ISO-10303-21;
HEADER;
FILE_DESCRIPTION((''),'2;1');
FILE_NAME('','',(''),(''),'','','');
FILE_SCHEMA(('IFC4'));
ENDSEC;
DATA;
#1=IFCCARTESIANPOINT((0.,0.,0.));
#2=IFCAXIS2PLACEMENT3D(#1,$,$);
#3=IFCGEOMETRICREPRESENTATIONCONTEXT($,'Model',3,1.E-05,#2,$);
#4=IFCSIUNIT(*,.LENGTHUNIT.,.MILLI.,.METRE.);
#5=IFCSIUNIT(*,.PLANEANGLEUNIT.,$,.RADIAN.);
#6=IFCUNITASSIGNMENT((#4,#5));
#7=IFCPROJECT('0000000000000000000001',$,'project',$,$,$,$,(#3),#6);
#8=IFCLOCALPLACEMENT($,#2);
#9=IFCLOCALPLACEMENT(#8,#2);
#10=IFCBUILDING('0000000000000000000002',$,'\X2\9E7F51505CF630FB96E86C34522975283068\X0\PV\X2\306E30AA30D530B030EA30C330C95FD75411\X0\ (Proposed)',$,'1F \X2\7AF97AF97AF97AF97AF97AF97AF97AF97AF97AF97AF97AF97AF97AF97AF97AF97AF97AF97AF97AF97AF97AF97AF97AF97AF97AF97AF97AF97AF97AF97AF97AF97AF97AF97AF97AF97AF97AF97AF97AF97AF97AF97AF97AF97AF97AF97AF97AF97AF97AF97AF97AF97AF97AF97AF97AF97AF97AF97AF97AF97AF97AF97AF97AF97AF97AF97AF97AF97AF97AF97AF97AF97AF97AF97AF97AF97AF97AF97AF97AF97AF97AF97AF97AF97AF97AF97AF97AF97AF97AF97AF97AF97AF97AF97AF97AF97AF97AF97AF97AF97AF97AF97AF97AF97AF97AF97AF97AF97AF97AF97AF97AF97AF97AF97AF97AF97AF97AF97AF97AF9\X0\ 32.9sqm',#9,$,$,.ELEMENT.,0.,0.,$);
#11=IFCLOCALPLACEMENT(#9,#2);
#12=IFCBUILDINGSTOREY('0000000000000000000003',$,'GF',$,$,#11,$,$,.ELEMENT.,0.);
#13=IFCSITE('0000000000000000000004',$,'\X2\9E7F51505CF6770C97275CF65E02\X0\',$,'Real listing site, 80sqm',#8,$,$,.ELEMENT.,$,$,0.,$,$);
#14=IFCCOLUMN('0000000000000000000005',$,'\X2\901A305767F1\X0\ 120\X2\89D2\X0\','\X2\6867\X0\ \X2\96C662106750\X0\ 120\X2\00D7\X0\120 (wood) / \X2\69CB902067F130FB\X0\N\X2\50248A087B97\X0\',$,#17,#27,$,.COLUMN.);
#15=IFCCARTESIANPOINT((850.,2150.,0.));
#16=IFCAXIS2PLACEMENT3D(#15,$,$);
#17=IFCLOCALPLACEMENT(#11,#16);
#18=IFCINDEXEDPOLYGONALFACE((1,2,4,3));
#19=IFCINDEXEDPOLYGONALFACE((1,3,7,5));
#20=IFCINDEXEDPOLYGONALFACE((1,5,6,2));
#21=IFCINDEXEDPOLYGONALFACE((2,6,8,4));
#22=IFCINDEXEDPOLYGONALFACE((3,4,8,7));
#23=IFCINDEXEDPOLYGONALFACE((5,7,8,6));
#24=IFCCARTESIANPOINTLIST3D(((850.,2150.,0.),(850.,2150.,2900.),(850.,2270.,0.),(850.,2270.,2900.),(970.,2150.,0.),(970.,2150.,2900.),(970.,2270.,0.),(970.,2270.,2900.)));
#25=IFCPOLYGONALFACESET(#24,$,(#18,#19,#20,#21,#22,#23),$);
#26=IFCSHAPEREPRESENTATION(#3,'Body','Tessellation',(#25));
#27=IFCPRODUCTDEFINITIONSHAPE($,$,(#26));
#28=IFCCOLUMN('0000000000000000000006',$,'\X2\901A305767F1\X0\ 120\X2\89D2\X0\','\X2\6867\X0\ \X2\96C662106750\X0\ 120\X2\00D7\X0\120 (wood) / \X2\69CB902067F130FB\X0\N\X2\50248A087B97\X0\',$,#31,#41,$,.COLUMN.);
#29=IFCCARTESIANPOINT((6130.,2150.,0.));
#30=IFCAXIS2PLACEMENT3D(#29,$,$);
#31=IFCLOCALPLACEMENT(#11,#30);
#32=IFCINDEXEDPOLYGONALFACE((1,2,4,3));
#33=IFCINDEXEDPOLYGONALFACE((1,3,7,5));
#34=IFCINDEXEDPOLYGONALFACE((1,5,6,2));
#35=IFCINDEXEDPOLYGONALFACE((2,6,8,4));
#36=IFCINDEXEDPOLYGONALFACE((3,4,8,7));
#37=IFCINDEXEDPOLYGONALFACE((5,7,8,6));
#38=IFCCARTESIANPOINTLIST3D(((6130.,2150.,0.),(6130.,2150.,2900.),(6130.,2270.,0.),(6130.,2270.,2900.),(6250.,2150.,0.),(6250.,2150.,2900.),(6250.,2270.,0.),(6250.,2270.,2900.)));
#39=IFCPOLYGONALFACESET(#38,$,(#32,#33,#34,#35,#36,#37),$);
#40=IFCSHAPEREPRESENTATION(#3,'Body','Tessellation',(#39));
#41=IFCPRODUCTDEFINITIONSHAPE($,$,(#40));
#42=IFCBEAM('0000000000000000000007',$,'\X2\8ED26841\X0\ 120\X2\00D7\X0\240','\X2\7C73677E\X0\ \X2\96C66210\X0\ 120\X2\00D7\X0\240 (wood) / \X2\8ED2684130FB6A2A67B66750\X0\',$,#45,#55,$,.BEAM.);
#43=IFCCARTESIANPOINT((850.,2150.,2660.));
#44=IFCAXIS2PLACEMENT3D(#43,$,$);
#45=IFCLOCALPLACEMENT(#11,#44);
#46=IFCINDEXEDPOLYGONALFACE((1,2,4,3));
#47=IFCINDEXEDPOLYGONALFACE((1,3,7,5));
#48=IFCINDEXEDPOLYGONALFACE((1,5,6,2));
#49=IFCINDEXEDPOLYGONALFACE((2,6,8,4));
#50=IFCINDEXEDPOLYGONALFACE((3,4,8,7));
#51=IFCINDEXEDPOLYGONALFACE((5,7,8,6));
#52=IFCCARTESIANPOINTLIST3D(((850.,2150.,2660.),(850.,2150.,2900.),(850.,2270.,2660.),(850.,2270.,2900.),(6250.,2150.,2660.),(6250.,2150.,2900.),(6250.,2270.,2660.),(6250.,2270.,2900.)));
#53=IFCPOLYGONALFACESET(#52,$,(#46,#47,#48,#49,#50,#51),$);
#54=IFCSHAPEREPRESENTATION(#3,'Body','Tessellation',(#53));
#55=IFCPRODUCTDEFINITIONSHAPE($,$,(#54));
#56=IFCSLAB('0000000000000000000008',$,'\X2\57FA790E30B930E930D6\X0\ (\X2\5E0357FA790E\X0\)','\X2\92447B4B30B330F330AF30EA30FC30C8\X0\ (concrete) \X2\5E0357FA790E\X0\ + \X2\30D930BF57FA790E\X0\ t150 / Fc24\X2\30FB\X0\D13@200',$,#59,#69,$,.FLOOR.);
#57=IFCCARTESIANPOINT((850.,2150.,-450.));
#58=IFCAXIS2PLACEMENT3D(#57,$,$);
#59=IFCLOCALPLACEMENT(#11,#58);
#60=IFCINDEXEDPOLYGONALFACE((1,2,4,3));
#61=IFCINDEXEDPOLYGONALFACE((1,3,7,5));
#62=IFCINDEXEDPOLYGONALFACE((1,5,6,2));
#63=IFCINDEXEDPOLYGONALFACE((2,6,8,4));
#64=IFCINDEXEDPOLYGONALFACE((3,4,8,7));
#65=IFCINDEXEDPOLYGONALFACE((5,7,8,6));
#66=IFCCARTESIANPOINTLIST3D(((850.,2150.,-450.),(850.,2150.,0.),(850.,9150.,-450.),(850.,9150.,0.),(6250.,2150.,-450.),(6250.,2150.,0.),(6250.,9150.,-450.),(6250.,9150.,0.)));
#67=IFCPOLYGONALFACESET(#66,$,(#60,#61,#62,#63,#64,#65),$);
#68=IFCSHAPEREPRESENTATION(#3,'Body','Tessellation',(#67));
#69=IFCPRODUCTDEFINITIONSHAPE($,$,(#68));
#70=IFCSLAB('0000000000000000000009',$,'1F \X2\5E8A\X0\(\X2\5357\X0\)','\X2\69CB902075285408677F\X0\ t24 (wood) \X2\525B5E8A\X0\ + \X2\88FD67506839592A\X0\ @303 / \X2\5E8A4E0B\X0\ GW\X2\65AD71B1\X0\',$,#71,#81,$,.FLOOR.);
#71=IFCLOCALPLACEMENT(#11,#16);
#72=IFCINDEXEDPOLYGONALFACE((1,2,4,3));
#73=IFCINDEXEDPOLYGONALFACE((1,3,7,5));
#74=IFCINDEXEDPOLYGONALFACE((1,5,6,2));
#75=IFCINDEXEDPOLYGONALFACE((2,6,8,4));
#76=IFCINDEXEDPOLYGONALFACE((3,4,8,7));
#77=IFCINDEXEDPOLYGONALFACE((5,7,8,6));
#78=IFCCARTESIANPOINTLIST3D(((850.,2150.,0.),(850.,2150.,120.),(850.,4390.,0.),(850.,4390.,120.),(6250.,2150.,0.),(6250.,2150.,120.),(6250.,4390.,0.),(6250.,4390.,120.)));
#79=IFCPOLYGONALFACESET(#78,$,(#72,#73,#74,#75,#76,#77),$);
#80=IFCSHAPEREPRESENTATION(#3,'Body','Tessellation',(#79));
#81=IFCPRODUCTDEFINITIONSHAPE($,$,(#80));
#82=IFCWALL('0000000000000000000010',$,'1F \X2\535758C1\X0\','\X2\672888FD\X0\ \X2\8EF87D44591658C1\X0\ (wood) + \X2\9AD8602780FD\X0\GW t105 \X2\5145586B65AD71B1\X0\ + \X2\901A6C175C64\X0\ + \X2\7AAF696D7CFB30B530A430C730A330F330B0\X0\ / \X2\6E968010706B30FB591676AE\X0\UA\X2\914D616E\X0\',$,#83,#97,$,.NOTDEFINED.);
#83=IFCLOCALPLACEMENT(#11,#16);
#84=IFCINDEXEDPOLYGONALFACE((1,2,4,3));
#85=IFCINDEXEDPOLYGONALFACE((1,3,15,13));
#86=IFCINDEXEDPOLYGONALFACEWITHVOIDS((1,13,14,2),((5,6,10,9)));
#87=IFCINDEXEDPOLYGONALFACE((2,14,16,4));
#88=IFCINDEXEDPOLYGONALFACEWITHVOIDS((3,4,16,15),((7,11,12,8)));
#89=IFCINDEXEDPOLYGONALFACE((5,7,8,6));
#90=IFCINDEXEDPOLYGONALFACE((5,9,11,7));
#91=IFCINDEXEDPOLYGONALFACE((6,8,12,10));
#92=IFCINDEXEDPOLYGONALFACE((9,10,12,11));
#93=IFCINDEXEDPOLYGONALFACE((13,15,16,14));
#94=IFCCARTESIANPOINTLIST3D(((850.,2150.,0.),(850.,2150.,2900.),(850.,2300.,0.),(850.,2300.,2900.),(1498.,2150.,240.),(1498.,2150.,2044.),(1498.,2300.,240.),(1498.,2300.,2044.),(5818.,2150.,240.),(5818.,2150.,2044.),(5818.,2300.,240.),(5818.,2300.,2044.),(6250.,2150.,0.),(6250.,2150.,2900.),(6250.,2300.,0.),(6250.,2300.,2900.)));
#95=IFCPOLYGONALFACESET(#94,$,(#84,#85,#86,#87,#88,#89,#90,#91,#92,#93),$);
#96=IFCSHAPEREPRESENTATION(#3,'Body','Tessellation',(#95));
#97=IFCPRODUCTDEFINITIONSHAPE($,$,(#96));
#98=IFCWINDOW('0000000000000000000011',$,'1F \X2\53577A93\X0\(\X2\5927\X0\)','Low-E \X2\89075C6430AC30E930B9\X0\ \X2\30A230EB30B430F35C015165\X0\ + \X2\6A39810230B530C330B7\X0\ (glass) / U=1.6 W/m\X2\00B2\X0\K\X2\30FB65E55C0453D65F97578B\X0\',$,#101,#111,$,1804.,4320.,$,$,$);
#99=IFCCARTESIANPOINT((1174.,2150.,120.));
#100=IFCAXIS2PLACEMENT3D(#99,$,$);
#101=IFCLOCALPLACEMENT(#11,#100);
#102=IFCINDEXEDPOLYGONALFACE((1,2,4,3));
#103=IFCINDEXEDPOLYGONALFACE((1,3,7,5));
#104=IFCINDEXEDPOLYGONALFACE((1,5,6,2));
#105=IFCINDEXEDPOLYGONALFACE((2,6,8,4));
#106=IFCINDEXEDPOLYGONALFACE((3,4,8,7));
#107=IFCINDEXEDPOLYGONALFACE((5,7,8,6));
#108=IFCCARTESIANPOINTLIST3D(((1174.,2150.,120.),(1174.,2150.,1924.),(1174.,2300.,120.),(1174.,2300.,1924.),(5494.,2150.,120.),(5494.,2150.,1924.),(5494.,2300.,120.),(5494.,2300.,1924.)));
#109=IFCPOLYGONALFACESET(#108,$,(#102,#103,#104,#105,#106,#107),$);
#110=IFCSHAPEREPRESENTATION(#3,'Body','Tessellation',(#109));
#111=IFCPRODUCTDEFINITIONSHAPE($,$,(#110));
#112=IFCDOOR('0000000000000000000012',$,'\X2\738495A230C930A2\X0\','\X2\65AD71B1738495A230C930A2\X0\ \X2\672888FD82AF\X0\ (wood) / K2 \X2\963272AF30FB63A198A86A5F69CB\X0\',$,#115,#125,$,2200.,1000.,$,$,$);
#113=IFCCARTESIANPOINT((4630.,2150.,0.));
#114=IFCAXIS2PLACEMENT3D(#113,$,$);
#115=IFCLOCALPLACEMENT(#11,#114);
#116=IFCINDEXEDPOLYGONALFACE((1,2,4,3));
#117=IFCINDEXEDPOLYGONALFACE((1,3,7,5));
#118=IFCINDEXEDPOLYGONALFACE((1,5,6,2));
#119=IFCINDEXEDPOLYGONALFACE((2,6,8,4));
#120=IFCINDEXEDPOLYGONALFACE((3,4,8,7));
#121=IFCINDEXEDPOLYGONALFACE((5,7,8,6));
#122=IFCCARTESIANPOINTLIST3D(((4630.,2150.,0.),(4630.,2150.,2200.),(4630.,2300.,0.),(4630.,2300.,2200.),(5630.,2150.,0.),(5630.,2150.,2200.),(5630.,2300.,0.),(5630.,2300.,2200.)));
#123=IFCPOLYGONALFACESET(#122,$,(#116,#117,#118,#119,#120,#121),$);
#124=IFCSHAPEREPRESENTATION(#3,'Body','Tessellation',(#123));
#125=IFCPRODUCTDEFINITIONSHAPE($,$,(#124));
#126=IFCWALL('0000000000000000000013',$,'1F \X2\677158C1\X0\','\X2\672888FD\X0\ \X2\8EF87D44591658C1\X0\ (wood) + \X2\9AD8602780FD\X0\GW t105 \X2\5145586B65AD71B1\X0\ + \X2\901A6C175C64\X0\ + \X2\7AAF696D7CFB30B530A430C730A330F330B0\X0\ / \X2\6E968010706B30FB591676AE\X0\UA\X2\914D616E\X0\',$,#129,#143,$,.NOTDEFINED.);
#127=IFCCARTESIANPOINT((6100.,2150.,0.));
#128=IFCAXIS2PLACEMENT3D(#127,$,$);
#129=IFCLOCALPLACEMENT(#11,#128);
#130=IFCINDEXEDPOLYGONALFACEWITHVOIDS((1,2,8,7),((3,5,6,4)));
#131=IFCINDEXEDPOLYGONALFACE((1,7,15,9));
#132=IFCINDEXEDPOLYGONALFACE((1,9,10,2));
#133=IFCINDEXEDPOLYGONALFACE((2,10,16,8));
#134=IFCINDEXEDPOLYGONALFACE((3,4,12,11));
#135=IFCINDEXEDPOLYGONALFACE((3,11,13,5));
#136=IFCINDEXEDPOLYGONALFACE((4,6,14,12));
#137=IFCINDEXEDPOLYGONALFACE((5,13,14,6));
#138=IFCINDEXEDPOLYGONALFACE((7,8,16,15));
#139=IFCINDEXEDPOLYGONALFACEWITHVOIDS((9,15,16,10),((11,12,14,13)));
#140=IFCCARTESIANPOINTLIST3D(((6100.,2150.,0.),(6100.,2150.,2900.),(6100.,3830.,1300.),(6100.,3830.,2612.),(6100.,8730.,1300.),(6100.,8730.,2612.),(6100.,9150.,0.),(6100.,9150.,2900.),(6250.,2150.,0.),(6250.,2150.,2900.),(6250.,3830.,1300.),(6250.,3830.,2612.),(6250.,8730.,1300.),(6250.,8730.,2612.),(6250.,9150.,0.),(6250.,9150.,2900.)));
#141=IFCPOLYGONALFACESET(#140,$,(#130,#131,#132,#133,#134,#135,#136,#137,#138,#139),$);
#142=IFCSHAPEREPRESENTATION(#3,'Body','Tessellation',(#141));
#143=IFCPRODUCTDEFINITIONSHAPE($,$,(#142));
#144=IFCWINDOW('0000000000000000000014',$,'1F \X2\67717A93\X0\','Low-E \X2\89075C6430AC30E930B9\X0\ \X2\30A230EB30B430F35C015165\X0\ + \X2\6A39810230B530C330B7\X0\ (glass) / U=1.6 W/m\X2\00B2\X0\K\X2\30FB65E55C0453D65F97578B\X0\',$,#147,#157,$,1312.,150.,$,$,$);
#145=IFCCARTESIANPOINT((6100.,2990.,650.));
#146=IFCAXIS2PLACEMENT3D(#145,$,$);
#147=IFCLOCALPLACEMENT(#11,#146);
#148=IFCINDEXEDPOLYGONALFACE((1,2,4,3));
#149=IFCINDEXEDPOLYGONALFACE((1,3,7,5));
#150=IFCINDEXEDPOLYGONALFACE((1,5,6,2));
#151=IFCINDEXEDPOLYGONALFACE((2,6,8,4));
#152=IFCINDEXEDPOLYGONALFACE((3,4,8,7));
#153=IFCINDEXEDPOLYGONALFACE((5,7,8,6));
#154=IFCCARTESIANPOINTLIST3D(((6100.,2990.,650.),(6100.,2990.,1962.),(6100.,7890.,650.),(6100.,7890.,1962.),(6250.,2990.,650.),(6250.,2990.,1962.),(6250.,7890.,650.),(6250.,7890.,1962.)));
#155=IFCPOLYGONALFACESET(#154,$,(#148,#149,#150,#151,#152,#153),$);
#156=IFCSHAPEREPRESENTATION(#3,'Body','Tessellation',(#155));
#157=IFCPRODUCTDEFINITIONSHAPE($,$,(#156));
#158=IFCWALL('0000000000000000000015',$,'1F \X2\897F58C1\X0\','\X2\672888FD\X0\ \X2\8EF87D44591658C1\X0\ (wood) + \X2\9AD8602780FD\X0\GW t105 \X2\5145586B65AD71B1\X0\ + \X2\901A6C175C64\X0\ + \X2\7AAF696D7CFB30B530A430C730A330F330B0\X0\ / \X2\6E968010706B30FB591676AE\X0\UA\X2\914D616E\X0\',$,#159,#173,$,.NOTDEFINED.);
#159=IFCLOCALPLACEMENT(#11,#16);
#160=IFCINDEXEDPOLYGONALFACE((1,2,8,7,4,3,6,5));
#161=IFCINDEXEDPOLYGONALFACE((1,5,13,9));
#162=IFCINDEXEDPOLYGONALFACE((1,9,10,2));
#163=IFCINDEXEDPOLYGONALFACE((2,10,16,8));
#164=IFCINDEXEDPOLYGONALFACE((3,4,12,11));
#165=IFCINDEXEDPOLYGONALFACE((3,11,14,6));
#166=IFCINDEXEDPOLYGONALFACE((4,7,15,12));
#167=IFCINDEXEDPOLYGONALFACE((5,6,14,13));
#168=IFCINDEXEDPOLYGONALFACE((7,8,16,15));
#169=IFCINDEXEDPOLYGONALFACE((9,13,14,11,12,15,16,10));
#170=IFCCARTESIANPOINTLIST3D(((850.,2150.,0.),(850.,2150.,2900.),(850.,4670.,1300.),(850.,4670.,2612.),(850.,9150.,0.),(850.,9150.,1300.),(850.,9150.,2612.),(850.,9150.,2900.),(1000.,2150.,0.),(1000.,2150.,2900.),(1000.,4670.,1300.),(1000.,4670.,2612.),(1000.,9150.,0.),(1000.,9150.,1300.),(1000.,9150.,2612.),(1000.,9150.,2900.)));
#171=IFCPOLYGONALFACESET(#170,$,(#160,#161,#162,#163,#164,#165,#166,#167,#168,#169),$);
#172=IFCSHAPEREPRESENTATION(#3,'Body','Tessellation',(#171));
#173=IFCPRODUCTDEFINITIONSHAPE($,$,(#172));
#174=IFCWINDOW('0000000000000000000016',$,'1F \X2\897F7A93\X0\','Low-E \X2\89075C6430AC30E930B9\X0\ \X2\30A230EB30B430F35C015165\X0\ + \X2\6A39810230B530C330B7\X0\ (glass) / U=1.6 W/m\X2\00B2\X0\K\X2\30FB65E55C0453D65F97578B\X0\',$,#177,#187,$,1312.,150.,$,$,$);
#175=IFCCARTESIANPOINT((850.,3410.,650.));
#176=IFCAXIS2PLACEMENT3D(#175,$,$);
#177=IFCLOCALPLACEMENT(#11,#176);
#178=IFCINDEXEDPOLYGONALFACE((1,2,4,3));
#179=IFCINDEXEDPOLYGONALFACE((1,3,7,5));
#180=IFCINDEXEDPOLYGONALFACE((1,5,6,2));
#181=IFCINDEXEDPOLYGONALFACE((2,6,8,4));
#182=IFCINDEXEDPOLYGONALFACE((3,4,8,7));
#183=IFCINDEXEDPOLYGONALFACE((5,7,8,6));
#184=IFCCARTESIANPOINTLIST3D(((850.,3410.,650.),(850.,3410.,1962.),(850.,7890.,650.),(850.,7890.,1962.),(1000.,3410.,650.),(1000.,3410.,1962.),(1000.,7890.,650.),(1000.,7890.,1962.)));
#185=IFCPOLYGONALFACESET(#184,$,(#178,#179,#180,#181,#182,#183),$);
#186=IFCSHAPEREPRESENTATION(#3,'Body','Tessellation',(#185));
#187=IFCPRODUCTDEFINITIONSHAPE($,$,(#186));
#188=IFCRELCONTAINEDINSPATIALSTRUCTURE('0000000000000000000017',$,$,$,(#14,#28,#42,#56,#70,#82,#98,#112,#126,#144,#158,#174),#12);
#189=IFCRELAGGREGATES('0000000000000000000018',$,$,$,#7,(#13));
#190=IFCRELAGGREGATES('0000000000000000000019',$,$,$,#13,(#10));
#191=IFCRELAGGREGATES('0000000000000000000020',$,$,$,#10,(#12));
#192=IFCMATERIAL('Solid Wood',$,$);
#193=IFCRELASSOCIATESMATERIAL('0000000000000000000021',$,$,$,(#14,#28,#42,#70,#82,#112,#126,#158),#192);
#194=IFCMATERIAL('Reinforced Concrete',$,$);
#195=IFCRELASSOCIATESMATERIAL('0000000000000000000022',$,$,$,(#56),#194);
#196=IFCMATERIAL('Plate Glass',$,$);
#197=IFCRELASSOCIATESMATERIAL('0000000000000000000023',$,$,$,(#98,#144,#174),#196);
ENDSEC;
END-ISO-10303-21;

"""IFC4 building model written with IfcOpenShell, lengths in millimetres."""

from ifc_helpers import new_model, si_unit, frame, frame_2d, origin, place, context, project, spatial, rectangle, extrude, material, element, fill, save


model = new_model("IFC4")

# Units and contexts
model_context = context("Model", 3, precision=1e-05, world=origin())
ifc_project = project(units=[si_unit("LENGTHUNIT", "METRE", prefix="MILLI"), si_unit("PLANEANGLEUNIT", "RADIAN")], contexts=[model_context])

# Site, building, storey
site_placement = place(None, origin())
site = spatial("IfcSite", under=ifc_project, at=site_placement, Name="鹿児島県霧島市", ObjectType="Real listing site, 80sqm", CompositionType="ELEMENT", RefElevation=0.0)
building_placement = place(site_placement, origin())
building = spatial("IfcBuilding", under=site, at=building_placement, Name="鹿児島・雨水利用とPVのオフグリッド志向 (Proposed)", ObjectType="1F 竹竹竹竹竹竹竹竹竹竹竹竹竹竹竹竹竹竹竹竹竹竹竹竹竹竹竹竹竹竹竹竹竹竹竹竹竹竹竹竹竹竹竹竹竹竹竹竹竹竹竹竹竹竹竹竹竹竹竹竹竹竹竹竹竹竹竹竹竹竹竹竹竹竹竹竹竹竹竹竹竹竹竹竹竹竹竹竹竹竹竹竹竹竹竹竹竹竹竹竹竹竹竹竹竹竹竹竹竹竹竹竹竹竹竹竹竹竹竹竹 32.9sqm", CompositionType="ELEMENT", ElevationOfRefHeight=0.0, ElevationOfTerrain=0.0)
storey_placement = place(building_placement, origin())
storey = spatial("IfcBuildingStorey", under=building, at=storey_placement, Name="GF", CompositionType="ELEMENT", Elevation=0.0)

# Columns
ifc_material_1 = material(Name="Solid Wood")
column_1_placement = place(storey_placement, frame((850.0, 2150.0, 0.0)))
element("IfcColumn", 1, at=column_1_placement, inside=storey, material=ifc_material_1, Name="通し柱 120角", Description="桧 集成材 120×120 (wood) / 構造柱・N値計算", PredefinedType="COLUMN", context=model_context, shape_type="SweptSolid", body=[
    extrude(rectangle(XDim=120.0, YDim=120.0, at=frame_2d((60.0, 60.0))), frame((850.0, 2150.0, 0.0)), (0.0, 0.0, 1.0), 2900.0),
])
column_2_placement = place(storey_placement, frame((6130.0, 2150.0, 0.0)))
element("IfcColumn", 2, at=column_2_placement, inside=storey, material=ifc_material_1, Name="通し柱 120角", Description="桧 集成材 120×120 (wood) / 構造柱・N値計算", PredefinedType="COLUMN", context=model_context, shape_type="SweptSolid", body=[
    extrude(rectangle(XDim=120.0, YDim=120.0, at=frame_2d((60.0, 60.0))), frame((6130.0, 2150.0, 0.0)), (0.0, 0.0, 1.0), 2900.0),
])

# Beam
beam_1_placement = place(storey_placement, frame((850.0, 2150.0, 2660.0)))
element("IfcBeam", 3, at=beam_1_placement, inside=storey, material=ifc_material_1, Name="軒桁 120×240", Description="米松 集成 120×240 (wood) / 軒桁・横架材", PredefinedType="BEAM", context=model_context, shape_type="SweptSolid", body=[
    extrude(rectangle(XDim=5400.0, YDim=120.0, at=frame_2d((2700.0, 60.0))), frame((850.0, 2150.0, 2660.0)), (0.0, 0.0, 1.0), 240.0),
])

# Slabs
ifc_material_2 = material(Name="Reinforced Concrete")
slab_1_placement = place(storey_placement, frame((850.0, 2150.0, -450.0)))
element("IfcSlab", 4, at=slab_1_placement, inside=storey, material=ifc_material_2, Name="基礎スラブ (布基礎)", Description="鉄筋コンクリート (concrete) 布基礎 + ベタ基礎 t150 / Fc24・D13@200", PredefinedType="FLOOR", context=model_context, shape_type="SweptSolid", body=[
    extrude(rectangle(XDim=5400.0, YDim=7000.0, at=frame_2d((2700.0, 3500.0))), frame((850.0, 2150.0, -450.0)), (0.0, 0.0, 1.0), 450.0),
])
slab_2_placement = place(storey_placement, frame((850.0, 2150.0, 0.0)))
element("IfcSlab", 5, at=slab_2_placement, inside=storey, material=ifc_material_1, Name="1F 床(南)", Description="構造用合板 t24 (wood) 剛床 + 製材根太 @303 / 床下 GW断熱", PredefinedType="FLOOR", context=model_context, shape_type="SweptSolid", body=[
    extrude(rectangle(XDim=5400.0, YDim=2240.0, at=frame_2d((2700.0, 1120.0))), frame((850.0, 2150.0, 0.0)), (0.0, 0.0, 1.0), 120.0),
])

# Wall, openings, window, door
wall_1_placement = place(storey_placement, frame((850.0, 2150.0, 0.0)))
wall_1 = element("IfcWall", 6, at=wall_1_placement, inside=storey, material=ifc_material_1, Name="1F 南壁", Description="木製 軸組外壁 (wood) + 高性能GW t105 充填断熱 + 通気層 + 窯業系サイディング / 準耐火・外皮UA配慮", PredefinedType="NOTDEFINED", context=model_context, shape_type="SweptSolid", body=[
    extrude(rectangle(XDim=5400.0, YDim=150.0, at=frame_2d((2700.0, 75.0))), frame((850.0, 2150.0, 0.0)), (0.0, 0.0, 1.0), 2900.0),
])
opening_1_placement = place(storey_placement, frame((1174.0, 2150.0, 120.0)))
opening_1 = element("IfcOpeningElement", 7, at=opening_1_placement, cuts=wall_1, PredefinedType="NOTDEFINED", context=model_context, shape_type="SweptSolid", body=[
    extrude(rectangle(XDim=4320.0, YDim=150.0, at=frame_2d((2160.0, 75.0))), frame((1174.0, 2150.0, 120.0)), (0.0, 0.0, 1.0), 1804.0),
])
opening_2_placement = place(storey_placement, frame((4630.0, 2150.0, 0.0)))
opening_2 = element("IfcOpeningElement", 8, at=opening_2_placement, cuts=wall_1, PredefinedType="NOTDEFINED", context=model_context, shape_type="SweptSolid", body=[
    extrude(rectangle(XDim=1000.0, YDim=150.0, at=frame_2d((500.0, 75.0))), frame((4630.0, 2150.0, 0.0)), (0.0, 0.0, 1.0), 2200.0),
])
ifc_material_3 = material(Name="Plate Glass")
window_1_placement = place(storey_placement, frame((1174.0, 2150.0, 120.0)))
window_1 = element("IfcWindow", 9, at=window_1_placement, inside=storey, material=ifc_material_3, Name="1F 南窓(大)", Description="Low-E 複層ガラス アルゴン封入 + 樹脂サッシ (glass) / U=1.6 W/m²K・日射取得型", OverallHeight=1804.0, OverallWidth=4320.0, context=model_context, shape_type="SweptSolid", body=[
    extrude(rectangle(XDim=4320.0, YDim=150.0, at=frame_2d((2160.0, 75.0))), frame((1174.0, 2150.0, 120.0)), (0.0, 0.0, 1.0), 1804.0),
])
fill(opening_1, window_1)
door_placement = place(storey_placement, frame((4630.0, 2150.0, 0.0)))
door = element("IfcDoor", 10, at=door_placement, inside=storey, material=ifc_material_1, Name="玄関ドア", Description="断熱玄関ドア 木製芯 (wood) / K2 防犯・採風機構", OverallHeight=2200.0, OverallWidth=1000.0, context=model_context, shape_type="SweptSolid", body=[
    extrude(rectangle(XDim=1000.0, YDim=150.0, at=frame_2d((500.0, 75.0))), frame((4630.0, 2150.0, 0.0)), (0.0, 0.0, 1.0), 2200.0),
])
fill(opening_2, door)

# Walls, openings, windows
wall_2_placement = place(storey_placement, frame((6100.0, 2150.0, 0.0)))
wall_2 = element("IfcWall", 11, at=wall_2_placement, inside=storey, material=ifc_material_1, Name="1F 東壁", Description="木製 軸組外壁 (wood) + 高性能GW t105 充填断熱 + 通気層 + 窯業系サイディング / 準耐火・外皮UA配慮", PredefinedType="NOTDEFINED", context=model_context, shape_type="SweptSolid", body=[
    extrude(rectangle(XDim=150.0, YDim=7000.0, at=frame_2d((75.0, 3500.0))), frame((6100.0, 2150.0, 0.0)), (0.0, 0.0, 1.0), 2900.0),
])
opening_3_placement = place(storey_placement, frame((6100.0, 2990.0, 650.0)))
opening_3 = element("IfcOpeningElement", 12, at=opening_3_placement, cuts=wall_2, PredefinedType="NOTDEFINED", context=model_context, shape_type="SweptSolid", body=[
    extrude(rectangle(XDim=150.0, YDim=4900.0, at=frame_2d((75.0, 2450.0))), frame((6100.0, 2990.0, 650.0)), (0.0, 0.0, 1.0), 1312.0),
])
window_2_placement = place(storey_placement, frame((6100.0, 2990.0, 650.0)))
window_2 = element("IfcWindow", 13, at=window_2_placement, inside=storey, material=ifc_material_3, Name="1F 東窓", Description="Low-E 複層ガラス アルゴン封入 + 樹脂サッシ (glass) / U=1.6 W/m²K・日射取得型", OverallHeight=1312.0, OverallWidth=150.0, context=model_context, shape_type="SweptSolid", body=[
    extrude(rectangle(XDim=150.0, YDim=4900.0, at=frame_2d((75.0, 2450.0))), frame((6100.0, 2990.0, 650.0)), (0.0, 0.0, 1.0), 1312.0),
])
fill(opening_3, window_2)
wall_3_placement = place(storey_placement, frame((850.0, 2150.0, 0.0)))
wall_3 = element("IfcWall", 14, at=wall_3_placement, inside=storey, material=ifc_material_1, Name="1F 西壁", Description="木製 軸組外壁 (wood) + 高性能GW t105 充填断熱 + 通気層 + 窯業系サイディング / 準耐火・外皮UA配慮", PredefinedType="NOTDEFINED", context=model_context, shape_type="SweptSolid", body=[
    extrude(rectangle(XDim=150.0, YDim=7000.0, at=frame_2d((75.0, 3500.0))), frame((850.0, 2150.0, 0.0)), (0.0, 0.0, 1.0), 2900.0),
])
opening_4_placement = place(storey_placement, frame((850.0, 3410.0, 650.0)))
opening_4 = element("IfcOpeningElement", 15, at=opening_4_placement, cuts=wall_3, PredefinedType="NOTDEFINED", context=model_context, shape_type="SweptSolid", body=[
    extrude(rectangle(XDim=150.0, YDim=4480.0, at=frame_2d((75.0, 2240.0))), frame((850.0, 3410.0, 650.0)), (0.0, 0.0, 1.0), 1312.0),
])
window_3_placement = place(storey_placement, frame((850.0, 3410.0, 650.0)))
window_3 = element("IfcWindow", 16, at=window_3_placement, inside=storey, material=ifc_material_3, Name="1F 西窓", Description="Low-E 複層ガラス アルゴン封入 + 樹脂サッシ (glass) / U=1.6 W/m²K・日射取得型", OverallHeight=1312.0, OverallWidth=150.0, context=model_context, shape_type="SweptSolid", body=[
    extrude(rectangle(XDim=150.0, YDim=4480.0, at=frame_2d((75.0, 2240.0))), frame((850.0, 3410.0, 650.0)), (0.0, 0.0, 1.0), 1312.0),
])
fill(opening_4, window_3)

save(model, "model.ifc")
